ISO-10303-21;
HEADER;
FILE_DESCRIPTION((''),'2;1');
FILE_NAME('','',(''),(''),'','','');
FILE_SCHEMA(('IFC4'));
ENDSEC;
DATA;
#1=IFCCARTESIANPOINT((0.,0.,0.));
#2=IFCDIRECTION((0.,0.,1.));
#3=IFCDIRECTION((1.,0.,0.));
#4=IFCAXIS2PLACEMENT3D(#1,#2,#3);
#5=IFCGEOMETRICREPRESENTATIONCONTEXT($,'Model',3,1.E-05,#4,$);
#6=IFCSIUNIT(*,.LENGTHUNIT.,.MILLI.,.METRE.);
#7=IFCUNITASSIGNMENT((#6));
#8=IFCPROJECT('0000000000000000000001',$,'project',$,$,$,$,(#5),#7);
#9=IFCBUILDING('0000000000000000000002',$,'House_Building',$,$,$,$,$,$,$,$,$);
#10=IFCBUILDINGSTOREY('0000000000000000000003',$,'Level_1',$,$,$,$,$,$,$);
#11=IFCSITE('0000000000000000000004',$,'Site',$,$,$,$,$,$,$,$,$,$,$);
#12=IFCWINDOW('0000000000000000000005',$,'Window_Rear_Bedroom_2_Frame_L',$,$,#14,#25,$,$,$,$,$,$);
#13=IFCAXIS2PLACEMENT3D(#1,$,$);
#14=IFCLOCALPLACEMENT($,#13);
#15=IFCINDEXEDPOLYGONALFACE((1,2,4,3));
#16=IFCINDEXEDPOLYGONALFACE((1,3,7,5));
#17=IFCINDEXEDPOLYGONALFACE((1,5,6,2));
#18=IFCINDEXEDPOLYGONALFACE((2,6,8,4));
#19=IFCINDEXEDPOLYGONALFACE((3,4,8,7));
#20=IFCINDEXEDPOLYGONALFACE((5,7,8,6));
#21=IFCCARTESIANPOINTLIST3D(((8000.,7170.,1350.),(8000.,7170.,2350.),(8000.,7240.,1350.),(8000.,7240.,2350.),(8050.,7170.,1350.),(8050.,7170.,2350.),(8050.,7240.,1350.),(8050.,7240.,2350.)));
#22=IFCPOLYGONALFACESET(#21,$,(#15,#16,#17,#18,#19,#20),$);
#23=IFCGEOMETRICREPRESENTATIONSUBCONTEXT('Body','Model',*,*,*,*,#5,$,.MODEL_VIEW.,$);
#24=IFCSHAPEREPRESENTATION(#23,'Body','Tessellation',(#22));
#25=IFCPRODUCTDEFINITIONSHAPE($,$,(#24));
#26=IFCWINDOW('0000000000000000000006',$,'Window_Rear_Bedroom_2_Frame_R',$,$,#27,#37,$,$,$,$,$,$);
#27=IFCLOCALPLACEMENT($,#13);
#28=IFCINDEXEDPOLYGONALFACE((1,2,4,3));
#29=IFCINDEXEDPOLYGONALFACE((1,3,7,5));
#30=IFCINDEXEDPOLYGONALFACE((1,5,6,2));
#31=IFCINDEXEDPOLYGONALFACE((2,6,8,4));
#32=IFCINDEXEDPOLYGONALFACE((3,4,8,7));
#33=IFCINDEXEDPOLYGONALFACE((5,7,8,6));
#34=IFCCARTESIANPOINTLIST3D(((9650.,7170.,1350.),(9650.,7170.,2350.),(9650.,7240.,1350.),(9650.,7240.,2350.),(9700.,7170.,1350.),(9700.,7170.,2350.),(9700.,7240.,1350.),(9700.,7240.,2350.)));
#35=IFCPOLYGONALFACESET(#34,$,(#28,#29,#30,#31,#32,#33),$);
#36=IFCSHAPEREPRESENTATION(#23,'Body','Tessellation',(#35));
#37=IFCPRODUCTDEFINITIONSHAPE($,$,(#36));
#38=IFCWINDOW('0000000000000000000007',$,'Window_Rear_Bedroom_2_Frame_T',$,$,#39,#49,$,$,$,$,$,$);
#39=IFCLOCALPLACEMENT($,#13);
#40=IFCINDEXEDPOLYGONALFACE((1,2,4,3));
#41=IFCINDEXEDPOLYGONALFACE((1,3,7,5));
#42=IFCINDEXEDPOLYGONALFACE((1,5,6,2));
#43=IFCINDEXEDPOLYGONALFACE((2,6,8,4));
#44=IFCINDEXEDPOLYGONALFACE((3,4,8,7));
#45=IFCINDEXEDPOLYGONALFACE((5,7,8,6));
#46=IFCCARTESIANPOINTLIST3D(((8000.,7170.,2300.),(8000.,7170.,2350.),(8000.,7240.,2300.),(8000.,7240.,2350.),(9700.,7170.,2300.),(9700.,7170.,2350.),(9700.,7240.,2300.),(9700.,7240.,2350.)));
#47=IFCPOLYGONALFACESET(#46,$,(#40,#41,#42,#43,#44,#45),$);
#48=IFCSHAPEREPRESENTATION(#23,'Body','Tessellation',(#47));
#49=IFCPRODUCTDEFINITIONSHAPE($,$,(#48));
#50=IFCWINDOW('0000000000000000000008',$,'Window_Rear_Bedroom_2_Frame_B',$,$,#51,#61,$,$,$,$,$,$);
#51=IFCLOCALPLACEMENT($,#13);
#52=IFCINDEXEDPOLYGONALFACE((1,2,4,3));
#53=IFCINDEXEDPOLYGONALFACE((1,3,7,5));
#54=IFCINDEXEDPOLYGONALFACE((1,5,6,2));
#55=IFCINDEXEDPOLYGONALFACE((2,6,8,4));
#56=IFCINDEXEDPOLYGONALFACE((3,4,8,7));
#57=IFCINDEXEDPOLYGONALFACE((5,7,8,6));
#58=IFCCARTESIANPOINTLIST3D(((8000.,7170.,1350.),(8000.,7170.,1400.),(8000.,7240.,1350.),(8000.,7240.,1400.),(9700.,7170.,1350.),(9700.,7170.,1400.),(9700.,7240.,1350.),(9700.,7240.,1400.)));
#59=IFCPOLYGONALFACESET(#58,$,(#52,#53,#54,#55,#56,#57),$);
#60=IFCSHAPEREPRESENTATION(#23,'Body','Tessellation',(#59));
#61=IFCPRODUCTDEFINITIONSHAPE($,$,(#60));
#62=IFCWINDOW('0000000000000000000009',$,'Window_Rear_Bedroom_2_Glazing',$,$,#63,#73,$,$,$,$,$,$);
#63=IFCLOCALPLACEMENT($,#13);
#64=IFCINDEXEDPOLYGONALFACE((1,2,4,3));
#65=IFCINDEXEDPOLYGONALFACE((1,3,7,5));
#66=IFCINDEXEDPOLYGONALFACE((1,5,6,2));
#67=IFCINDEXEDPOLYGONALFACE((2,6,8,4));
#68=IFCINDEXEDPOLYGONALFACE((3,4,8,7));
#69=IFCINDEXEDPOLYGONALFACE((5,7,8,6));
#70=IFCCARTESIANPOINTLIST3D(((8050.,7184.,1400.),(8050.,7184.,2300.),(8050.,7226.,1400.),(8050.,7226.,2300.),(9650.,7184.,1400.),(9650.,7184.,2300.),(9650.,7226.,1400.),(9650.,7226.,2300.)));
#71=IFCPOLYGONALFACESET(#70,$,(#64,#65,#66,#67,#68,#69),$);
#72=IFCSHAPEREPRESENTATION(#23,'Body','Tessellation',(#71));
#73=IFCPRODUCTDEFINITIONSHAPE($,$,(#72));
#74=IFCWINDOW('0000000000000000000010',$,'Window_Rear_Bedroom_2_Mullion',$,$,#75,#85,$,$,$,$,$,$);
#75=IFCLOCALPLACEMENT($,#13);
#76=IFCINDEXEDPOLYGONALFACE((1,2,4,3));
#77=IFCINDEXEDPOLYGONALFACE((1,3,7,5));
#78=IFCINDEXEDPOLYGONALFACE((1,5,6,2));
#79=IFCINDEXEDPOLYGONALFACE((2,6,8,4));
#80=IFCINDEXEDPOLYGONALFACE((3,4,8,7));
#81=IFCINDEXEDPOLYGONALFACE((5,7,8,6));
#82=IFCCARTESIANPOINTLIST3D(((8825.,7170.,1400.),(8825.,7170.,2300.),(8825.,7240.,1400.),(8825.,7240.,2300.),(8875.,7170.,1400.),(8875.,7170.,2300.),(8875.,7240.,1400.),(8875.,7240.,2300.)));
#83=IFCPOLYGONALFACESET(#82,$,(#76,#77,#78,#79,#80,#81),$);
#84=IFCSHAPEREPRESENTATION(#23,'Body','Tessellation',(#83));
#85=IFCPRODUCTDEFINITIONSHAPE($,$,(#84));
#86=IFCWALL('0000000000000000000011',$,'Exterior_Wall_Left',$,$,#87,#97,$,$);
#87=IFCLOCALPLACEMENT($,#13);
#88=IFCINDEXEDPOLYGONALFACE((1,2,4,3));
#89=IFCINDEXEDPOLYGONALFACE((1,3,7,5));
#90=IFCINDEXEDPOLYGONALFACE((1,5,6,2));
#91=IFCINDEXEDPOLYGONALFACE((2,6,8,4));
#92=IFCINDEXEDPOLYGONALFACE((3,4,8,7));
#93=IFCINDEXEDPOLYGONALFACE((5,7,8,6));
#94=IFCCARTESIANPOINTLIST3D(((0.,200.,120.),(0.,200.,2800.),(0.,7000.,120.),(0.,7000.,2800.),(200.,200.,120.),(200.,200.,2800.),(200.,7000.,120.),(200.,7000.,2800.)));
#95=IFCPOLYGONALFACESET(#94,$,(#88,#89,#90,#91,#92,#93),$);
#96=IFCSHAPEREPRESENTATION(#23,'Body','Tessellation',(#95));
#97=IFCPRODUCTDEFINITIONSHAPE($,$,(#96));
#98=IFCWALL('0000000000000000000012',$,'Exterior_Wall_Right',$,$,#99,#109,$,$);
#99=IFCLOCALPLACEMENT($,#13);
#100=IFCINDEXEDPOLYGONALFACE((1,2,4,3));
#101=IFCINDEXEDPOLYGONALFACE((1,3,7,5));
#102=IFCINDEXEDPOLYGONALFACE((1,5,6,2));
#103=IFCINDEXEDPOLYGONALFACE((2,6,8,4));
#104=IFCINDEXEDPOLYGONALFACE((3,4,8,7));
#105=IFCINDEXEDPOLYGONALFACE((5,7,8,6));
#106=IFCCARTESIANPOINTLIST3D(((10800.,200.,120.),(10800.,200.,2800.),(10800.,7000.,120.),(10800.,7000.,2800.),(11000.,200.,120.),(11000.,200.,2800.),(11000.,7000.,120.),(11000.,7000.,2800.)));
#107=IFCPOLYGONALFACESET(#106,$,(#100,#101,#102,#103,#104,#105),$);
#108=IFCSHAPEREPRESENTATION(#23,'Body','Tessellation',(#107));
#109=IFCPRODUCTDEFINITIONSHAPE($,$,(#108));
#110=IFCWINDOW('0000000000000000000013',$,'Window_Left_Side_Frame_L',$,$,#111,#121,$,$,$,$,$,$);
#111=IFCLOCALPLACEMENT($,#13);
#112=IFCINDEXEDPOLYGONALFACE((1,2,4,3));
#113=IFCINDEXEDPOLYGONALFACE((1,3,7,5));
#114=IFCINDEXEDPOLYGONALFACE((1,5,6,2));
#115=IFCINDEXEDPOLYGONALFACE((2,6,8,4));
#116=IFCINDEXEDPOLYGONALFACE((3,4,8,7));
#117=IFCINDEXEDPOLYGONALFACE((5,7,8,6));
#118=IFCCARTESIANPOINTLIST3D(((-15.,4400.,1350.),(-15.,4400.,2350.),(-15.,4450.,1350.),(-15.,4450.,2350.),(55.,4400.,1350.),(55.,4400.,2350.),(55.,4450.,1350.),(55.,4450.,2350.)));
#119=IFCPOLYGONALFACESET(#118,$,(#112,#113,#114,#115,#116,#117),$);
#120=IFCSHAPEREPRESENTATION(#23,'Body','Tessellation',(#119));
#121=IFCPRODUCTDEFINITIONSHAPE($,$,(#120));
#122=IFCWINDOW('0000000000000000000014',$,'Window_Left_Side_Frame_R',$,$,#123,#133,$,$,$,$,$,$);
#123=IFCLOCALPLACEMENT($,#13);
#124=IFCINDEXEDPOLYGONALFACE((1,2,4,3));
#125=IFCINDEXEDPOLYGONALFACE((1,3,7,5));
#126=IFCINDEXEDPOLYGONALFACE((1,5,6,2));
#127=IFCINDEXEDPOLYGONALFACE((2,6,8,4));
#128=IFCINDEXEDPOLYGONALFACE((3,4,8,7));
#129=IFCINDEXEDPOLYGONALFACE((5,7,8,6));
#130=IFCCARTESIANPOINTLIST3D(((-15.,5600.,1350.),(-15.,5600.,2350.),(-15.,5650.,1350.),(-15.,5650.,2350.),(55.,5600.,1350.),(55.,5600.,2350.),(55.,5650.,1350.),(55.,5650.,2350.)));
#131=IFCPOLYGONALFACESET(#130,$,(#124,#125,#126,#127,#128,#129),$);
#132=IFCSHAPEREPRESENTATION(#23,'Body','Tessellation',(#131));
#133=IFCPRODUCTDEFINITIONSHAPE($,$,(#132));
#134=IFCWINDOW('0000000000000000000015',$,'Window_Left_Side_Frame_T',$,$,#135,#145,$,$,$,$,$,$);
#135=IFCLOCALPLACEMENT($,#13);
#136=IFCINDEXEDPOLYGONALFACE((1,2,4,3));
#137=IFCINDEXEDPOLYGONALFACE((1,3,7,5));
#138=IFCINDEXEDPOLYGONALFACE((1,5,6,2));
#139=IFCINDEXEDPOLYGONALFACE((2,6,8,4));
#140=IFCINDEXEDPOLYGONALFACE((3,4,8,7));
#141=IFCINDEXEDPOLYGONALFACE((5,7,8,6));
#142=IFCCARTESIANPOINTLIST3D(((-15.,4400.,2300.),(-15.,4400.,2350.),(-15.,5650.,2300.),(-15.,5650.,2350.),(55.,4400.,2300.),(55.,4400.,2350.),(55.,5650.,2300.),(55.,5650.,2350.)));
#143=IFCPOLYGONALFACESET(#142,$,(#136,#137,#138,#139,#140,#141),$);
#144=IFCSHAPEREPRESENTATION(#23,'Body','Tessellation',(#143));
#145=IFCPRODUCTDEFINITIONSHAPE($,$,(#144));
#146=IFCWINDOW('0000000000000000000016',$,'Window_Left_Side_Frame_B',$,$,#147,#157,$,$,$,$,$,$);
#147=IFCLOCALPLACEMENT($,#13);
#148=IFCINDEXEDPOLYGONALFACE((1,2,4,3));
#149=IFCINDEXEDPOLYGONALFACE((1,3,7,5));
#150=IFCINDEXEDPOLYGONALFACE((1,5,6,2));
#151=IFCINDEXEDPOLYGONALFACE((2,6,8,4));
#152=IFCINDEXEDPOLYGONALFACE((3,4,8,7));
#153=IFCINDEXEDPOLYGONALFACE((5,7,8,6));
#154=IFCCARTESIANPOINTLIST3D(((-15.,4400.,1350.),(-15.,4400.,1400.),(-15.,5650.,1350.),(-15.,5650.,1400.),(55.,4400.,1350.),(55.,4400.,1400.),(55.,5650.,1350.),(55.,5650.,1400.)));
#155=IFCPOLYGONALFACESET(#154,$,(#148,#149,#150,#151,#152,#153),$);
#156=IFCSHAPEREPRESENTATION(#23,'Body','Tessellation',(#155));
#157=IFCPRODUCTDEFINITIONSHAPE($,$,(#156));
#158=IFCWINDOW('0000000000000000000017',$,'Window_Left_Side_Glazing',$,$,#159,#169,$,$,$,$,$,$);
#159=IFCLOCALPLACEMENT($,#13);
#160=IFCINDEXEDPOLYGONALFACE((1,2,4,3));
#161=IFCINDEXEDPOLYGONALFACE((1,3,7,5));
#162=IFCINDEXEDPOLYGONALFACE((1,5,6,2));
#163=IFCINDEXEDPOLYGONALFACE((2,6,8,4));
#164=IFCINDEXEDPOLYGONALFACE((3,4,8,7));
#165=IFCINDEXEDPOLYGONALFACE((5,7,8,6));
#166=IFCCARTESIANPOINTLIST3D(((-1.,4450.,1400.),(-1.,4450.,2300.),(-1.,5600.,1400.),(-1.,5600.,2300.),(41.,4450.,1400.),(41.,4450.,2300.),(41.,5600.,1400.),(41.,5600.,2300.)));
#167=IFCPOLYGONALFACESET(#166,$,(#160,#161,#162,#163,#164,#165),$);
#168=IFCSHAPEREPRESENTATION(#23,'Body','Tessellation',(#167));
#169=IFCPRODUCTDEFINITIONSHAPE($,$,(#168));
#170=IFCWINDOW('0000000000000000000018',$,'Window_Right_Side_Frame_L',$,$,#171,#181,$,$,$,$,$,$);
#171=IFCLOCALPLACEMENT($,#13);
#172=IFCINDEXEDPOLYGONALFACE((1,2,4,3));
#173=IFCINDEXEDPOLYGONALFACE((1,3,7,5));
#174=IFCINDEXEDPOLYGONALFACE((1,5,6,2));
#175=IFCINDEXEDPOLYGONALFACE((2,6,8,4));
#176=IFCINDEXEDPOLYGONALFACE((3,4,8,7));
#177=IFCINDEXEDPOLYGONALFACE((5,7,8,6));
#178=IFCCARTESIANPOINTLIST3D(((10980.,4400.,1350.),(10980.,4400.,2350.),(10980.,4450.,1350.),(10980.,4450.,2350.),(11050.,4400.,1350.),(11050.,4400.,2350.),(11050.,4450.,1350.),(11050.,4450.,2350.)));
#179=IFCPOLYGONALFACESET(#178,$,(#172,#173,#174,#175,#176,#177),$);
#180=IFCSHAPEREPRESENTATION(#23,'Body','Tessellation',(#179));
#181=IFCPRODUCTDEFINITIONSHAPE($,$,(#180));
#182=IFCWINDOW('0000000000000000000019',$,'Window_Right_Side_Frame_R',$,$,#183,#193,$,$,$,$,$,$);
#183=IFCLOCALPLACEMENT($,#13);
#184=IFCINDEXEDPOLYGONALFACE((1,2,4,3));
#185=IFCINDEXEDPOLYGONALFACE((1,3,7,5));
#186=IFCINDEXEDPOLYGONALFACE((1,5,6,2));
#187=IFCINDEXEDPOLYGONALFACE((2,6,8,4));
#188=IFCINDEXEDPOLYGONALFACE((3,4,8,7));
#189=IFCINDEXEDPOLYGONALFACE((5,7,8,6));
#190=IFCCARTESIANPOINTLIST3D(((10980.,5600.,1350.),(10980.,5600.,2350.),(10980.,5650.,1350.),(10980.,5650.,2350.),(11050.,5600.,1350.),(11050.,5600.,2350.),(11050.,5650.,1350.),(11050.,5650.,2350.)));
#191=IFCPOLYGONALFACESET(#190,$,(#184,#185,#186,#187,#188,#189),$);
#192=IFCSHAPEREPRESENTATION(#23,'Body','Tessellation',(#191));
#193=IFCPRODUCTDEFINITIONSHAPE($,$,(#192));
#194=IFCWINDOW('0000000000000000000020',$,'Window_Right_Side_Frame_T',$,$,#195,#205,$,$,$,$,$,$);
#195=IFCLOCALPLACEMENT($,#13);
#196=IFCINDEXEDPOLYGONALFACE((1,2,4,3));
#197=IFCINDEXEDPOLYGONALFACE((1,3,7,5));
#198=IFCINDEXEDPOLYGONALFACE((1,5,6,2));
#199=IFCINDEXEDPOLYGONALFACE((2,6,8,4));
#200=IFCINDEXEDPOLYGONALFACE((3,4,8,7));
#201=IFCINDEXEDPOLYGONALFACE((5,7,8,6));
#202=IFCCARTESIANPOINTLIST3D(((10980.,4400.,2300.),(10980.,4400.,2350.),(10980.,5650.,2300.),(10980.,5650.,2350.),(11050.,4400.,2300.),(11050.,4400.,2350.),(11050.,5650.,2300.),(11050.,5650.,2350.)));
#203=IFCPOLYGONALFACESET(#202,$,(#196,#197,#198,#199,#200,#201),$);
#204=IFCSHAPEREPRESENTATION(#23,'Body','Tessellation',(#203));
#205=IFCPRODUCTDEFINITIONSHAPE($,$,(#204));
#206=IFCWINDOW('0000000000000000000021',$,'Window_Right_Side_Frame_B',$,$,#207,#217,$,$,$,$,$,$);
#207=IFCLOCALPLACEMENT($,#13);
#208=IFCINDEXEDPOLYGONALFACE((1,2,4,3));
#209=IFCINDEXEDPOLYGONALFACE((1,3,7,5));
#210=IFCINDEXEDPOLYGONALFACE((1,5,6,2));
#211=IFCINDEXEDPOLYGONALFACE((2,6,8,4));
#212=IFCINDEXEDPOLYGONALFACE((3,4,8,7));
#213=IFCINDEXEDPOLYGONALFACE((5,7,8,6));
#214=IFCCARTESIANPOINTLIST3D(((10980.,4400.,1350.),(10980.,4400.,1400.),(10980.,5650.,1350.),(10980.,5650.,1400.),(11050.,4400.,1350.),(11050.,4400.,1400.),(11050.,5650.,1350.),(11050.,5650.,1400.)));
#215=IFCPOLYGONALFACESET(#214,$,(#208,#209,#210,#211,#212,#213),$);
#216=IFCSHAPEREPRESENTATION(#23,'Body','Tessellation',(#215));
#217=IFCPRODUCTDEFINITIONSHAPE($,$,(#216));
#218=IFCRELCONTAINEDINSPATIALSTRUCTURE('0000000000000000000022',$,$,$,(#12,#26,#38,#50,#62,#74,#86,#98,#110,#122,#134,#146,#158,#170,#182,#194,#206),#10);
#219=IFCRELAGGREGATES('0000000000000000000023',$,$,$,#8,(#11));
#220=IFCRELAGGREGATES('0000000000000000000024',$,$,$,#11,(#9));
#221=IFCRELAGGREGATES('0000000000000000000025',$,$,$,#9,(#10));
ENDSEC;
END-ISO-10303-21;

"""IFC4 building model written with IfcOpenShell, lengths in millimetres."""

from ifc_helpers import new_model, si_unit, frame, origin_with_axes, context, subcontext, project, spatial, polyline, outline, extrude, element, save


model = new_model("IFC4")

# Units and contexts
model_context = context("Model", 3, precision=1e-05, world=origin_with_axes())
body_context = subcontext(model_context, "Body", "Model", "MODEL_VIEW")
ifc_project = project(units=[si_unit("LENGTHUNIT", "METRE", prefix="MILLI")], contexts=[model_context])

# Site, building, storey
site = spatial("IfcSite", under=ifc_project, Name="Site")
building = spatial("IfcBuilding", under=site, Name="House_Building")
storey = spatial("IfcBuildingStorey", under=building, Name="Level_1")

# Windows
element("IfcWindow", 1, inside=storey, Name="Window_Rear_Bedroom_2_Frame_L", context=body_context, shape_type="SweptSolid", body=[
    extrude(outline(polyline([(8000.0, 7170.0), (8050.0, 7170.0), (8050.0, 7240.0), (8000.0, 7240.0), (8000.0, 7170.0)])), frame((0.0, 0.0, 1350.0), z_axis=(0.0, 0.0, 1.0), x_axis=(1.0, 0.0, 0.0)), (0.0, 0.0, 1.0), 1000.0),
])
element("IfcWindow", 2, inside=storey, Name="Window_Rear_Bedroom_2_Frame_R", context=body_context, shape_type="SweptSolid", body=[
    extrude(outline(polyline([(9650.0, 7170.0), (9700.0, 7170.0), (9700.0, 7240.0), (9650.0, 7240.0), (9650.0, 7170.0)])), frame((0.0, 0.0, 1350.0), z_axis=(0.0, 0.0, 1.0), x_axis=(1.0, 0.0, 0.0)), (0.0, 0.0, 1.0), 1000.0),
])
element("IfcWindow", 3, inside=storey, Name="Window_Rear_Bedroom_2_Frame_T", context=body_context, shape_type="SweptSolid", body=[
    extrude(outline(polyline([(8000.0, 7170.0), (9700.0, 7170.0), (9700.0, 7240.0), (8000.0, 7240.0), (8000.0, 7170.0)])), frame((0.0, 0.0, 2300.0), z_axis=(0.0, 0.0, 1.0), x_axis=(1.0, 0.0, 0.0)), (0.0, 0.0, 1.0), 50.0),
])
element("IfcWindow", 4, inside=storey, Name="Window_Rear_Bedroom_2_Frame_B", context=body_context, shape_type="SweptSolid", body=[
    extrude(outline(polyline([(8000.0, 7170.0), (9700.0, 7170.0), (9700.0, 7240.0), (8000.0, 7240.0), (8000.0, 7170.0)])), frame((0.0, 0.0, 1350.0), z_axis=(0.0, 0.0, 1.0), x_axis=(1.0, 0.0, 0.0)), (0.0, 0.0, 1.0), 50.0),
])
element("IfcWindow", 5, inside=storey, Name="Window_Rear_Bedroom_2_Glazing", context=body_context, shape_type="SweptSolid", body=[
    extrude(outline(polyline([(8050.0, 7184.0), (9650.0, 7184.0), (9650.0, 7226.0), (8050.0, 7226.0), (8050.0, 7184.0)])), frame((0.0, 0.0, 1400.0), z_axis=(0.0, 0.0, 1.0), x_axis=(1.0, 0.0, 0.0)), (0.0, 0.0, 1.0), 900.0),
])
element("IfcWindow", 6, inside=storey, Name="Window_Rear_Bedroom_2_Mullion", context=body_context, shape_type="SweptSolid", body=[
    extrude(outline(polyline([(8825.0, 7170.0), (8875.0, 7170.0), (8875.0, 7240.0), (8825.0, 7240.0), (8825.0, 7170.0)])), frame((0.0, 0.0, 1400.0), z_axis=(0.0, 0.0, 1.0), x_axis=(1.0, 0.0, 0.0)), (0.0, 0.0, 1.0), 900.0),
])

# Walls
element("IfcWall", 7, inside=storey, Name="Exterior_Wall_Left", context=body_context, shape_type="SweptSolid", body=[
    extrude(outline(polyline([(0.0, 200.0), (200.0, 200.0), (200.0, 7000.0), (0.0, 7000.0), (0.0, 200.0)])), frame((0.0, 0.0, 120.0), z_axis=(0.0, 0.0, 1.0), x_axis=(1.0, 0.0, 0.0)), (0.0, 0.0, 1.0), 2680.0),
])
element("IfcWall", 8, inside=storey, Name="Exterior_Wall_Right", context=body_context, shape_type="SweptSolid", body=[
    extrude(outline(polyline([(10800.0, 200.0), (11000.0, 200.0), (11000.0, 7000.0), (10800.0, 7000.0), (10800.0, 200.0)])), frame((0.0, 0.0, 120.0), z_axis=(0.0, 0.0, 1.0), x_axis=(1.0, 0.0, 0.0)), (0.0, 0.0, 1.0), 2680.0),
])

# Windows
element("IfcWindow", 9, inside=storey, Name="Window_Left_Side_Frame_L", context=body_context, shape_type="SweptSolid", body=[
    extrude(outline(polyline([(-15.0, 4400.0), (55.0, 4400.0), (55.0, 4450.0), (-15.0, 4450.0), (-15.0, 4400.0)])), frame((0.0, 0.0, 1350.0), z_axis=(0.0, 0.0, 1.0), x_axis=(1.0, 0.0, 0.0)), (0.0, 0.0, 1.0), 1000.0),
])
element("IfcWindow", 10, inside=storey, Name="Window_Left_Side_Frame_R", context=body_context, shape_type="SweptSolid", body=[
    extrude(outline(polyline([(-15.0, 5600.0), (55.0, 5600.0), (55.0, 5650.0), (-15.0, 5650.0), (-15.0, 5600.0)])), frame((0.0, 0.0, 1350.0), z_axis=(0.0, 0.0, 1.0), x_axis=(1.0, 0.0, 0.0)), (0.0, 0.0, 1.0), 1000.0),
])
element("IfcWindow", 11, inside=storey, Name="Window_Left_Side_Frame_T", context=body_context, shape_type="SweptSolid", body=[
    extrude(outline(polyline([(-15.0, 4400.0), (55.0, 4400.0), (55.0, 5650.0), (-15.0, 5650.0), (-15.0, 4400.0)])), frame((0.0, 0.0, 2300.0), z_axis=(0.0, 0.0, 1.0), x_axis=(1.0, 0.0, 0.0)), (0.0, 0.0, 1.0), 50.0),
])
element("IfcWindow", 12, inside=storey, Name="Window_Left_Side_Frame_B", context=body_context, shape_type="SweptSolid", body=[
    extrude(outline(polyline([(-15.0, 4400.0), (55.0, 4400.0), (55.0, 5650.0), (-15.0, 5650.0), (-15.0, 4400.0)])), frame((0.0, 0.0, 1350.0), z_axis=(0.0, 0.0, 1.0), x_axis=(1.0, 0.0, 0.0)), (0.0, 0.0, 1.0), 50.0),
])
element("IfcWindow", 13, inside=storey, Name="Window_Left_Side_Glazing", context=body_context, shape_type="SweptSolid", body=[
    extrude(outline(polyline([(-1.0, 4450.0), (41.0, 4450.0), (41.0, 5600.0), (-1.0, 5600.0), (-1.0, 4450.0)])), frame((0.0, 0.0, 1400.0), z_axis=(0.0, 0.0, 1.0), x_axis=(1.0, 0.0, 0.0)), (0.0, 0.0, 1.0), 900.0),
])
element("IfcWindow", 14, inside=storey, Name="Window_Right_Side_Frame_L", context=body_context, shape_type="SweptSolid", body=[
    extrude(outline(polyline([(10980.0, 4400.0), (11050.0, 4400.0), (11050.0, 4450.0), (10980.0, 4450.0), (10980.0, 4400.0)])), frame((0.0, 0.0, 1350.0), z_axis=(0.0, 0.0, 1.0), x_axis=(1.0, 0.0, 0.0)), (0.0, 0.0, 1.0), 1000.0),
])
element("IfcWindow", 15, inside=storey, Name="Window_Right_Side_Frame_R", context=body_context, shape_type="SweptSolid", body=[
    extrude(outline(polyline([(10980.0, 5600.0), (11050.0, 5600.0), (11050.0, 5650.0), (10980.0, 5650.0), (10980.0, 5600.0)])), frame((0.0, 0.0, 1350.0), z_axis=(0.0, 0.0, 1.0), x_axis=(1.0, 0.0, 0.0)), (0.0, 0.0, 1.0), 1000.0),
])
element("IfcWindow", 16, inside=storey, Name="Window_Right_Side_Frame_T", context=body_context, shape_type="SweptSolid", body=[
    extrude(outline(polyline([(10980.0, 4400.0), (11050.0, 4400.0), (11050.0, 5650.0), (10980.0, 5650.0), (10980.0, 4400.0)])), frame((0.0, 0.0, 2300.0), z_axis=(0.0, 0.0, 1.0), x_axis=(1.0, 0.0, 0.0)), (0.0, 0.0, 1.0), 50.0),
])
element("IfcWindow", 17, inside=storey, Name="Window_Right_Side_Frame_B", context=body_context, shape_type="SweptSolid", body=[
    extrude(outline(polyline([(10980.0, 4400.0), (11050.0, 4400.0), (11050.0, 5650.0), (10980.0, 5650.0), (10980.0, 4400.0)])), frame((0.0, 0.0, 1350.0), z_axis=(0.0, 0.0, 1.0), x_axis=(1.0, 0.0, 0.0)), (0.0, 0.0, 1.0), 50.0),
])

save(model, "model.ifc")
